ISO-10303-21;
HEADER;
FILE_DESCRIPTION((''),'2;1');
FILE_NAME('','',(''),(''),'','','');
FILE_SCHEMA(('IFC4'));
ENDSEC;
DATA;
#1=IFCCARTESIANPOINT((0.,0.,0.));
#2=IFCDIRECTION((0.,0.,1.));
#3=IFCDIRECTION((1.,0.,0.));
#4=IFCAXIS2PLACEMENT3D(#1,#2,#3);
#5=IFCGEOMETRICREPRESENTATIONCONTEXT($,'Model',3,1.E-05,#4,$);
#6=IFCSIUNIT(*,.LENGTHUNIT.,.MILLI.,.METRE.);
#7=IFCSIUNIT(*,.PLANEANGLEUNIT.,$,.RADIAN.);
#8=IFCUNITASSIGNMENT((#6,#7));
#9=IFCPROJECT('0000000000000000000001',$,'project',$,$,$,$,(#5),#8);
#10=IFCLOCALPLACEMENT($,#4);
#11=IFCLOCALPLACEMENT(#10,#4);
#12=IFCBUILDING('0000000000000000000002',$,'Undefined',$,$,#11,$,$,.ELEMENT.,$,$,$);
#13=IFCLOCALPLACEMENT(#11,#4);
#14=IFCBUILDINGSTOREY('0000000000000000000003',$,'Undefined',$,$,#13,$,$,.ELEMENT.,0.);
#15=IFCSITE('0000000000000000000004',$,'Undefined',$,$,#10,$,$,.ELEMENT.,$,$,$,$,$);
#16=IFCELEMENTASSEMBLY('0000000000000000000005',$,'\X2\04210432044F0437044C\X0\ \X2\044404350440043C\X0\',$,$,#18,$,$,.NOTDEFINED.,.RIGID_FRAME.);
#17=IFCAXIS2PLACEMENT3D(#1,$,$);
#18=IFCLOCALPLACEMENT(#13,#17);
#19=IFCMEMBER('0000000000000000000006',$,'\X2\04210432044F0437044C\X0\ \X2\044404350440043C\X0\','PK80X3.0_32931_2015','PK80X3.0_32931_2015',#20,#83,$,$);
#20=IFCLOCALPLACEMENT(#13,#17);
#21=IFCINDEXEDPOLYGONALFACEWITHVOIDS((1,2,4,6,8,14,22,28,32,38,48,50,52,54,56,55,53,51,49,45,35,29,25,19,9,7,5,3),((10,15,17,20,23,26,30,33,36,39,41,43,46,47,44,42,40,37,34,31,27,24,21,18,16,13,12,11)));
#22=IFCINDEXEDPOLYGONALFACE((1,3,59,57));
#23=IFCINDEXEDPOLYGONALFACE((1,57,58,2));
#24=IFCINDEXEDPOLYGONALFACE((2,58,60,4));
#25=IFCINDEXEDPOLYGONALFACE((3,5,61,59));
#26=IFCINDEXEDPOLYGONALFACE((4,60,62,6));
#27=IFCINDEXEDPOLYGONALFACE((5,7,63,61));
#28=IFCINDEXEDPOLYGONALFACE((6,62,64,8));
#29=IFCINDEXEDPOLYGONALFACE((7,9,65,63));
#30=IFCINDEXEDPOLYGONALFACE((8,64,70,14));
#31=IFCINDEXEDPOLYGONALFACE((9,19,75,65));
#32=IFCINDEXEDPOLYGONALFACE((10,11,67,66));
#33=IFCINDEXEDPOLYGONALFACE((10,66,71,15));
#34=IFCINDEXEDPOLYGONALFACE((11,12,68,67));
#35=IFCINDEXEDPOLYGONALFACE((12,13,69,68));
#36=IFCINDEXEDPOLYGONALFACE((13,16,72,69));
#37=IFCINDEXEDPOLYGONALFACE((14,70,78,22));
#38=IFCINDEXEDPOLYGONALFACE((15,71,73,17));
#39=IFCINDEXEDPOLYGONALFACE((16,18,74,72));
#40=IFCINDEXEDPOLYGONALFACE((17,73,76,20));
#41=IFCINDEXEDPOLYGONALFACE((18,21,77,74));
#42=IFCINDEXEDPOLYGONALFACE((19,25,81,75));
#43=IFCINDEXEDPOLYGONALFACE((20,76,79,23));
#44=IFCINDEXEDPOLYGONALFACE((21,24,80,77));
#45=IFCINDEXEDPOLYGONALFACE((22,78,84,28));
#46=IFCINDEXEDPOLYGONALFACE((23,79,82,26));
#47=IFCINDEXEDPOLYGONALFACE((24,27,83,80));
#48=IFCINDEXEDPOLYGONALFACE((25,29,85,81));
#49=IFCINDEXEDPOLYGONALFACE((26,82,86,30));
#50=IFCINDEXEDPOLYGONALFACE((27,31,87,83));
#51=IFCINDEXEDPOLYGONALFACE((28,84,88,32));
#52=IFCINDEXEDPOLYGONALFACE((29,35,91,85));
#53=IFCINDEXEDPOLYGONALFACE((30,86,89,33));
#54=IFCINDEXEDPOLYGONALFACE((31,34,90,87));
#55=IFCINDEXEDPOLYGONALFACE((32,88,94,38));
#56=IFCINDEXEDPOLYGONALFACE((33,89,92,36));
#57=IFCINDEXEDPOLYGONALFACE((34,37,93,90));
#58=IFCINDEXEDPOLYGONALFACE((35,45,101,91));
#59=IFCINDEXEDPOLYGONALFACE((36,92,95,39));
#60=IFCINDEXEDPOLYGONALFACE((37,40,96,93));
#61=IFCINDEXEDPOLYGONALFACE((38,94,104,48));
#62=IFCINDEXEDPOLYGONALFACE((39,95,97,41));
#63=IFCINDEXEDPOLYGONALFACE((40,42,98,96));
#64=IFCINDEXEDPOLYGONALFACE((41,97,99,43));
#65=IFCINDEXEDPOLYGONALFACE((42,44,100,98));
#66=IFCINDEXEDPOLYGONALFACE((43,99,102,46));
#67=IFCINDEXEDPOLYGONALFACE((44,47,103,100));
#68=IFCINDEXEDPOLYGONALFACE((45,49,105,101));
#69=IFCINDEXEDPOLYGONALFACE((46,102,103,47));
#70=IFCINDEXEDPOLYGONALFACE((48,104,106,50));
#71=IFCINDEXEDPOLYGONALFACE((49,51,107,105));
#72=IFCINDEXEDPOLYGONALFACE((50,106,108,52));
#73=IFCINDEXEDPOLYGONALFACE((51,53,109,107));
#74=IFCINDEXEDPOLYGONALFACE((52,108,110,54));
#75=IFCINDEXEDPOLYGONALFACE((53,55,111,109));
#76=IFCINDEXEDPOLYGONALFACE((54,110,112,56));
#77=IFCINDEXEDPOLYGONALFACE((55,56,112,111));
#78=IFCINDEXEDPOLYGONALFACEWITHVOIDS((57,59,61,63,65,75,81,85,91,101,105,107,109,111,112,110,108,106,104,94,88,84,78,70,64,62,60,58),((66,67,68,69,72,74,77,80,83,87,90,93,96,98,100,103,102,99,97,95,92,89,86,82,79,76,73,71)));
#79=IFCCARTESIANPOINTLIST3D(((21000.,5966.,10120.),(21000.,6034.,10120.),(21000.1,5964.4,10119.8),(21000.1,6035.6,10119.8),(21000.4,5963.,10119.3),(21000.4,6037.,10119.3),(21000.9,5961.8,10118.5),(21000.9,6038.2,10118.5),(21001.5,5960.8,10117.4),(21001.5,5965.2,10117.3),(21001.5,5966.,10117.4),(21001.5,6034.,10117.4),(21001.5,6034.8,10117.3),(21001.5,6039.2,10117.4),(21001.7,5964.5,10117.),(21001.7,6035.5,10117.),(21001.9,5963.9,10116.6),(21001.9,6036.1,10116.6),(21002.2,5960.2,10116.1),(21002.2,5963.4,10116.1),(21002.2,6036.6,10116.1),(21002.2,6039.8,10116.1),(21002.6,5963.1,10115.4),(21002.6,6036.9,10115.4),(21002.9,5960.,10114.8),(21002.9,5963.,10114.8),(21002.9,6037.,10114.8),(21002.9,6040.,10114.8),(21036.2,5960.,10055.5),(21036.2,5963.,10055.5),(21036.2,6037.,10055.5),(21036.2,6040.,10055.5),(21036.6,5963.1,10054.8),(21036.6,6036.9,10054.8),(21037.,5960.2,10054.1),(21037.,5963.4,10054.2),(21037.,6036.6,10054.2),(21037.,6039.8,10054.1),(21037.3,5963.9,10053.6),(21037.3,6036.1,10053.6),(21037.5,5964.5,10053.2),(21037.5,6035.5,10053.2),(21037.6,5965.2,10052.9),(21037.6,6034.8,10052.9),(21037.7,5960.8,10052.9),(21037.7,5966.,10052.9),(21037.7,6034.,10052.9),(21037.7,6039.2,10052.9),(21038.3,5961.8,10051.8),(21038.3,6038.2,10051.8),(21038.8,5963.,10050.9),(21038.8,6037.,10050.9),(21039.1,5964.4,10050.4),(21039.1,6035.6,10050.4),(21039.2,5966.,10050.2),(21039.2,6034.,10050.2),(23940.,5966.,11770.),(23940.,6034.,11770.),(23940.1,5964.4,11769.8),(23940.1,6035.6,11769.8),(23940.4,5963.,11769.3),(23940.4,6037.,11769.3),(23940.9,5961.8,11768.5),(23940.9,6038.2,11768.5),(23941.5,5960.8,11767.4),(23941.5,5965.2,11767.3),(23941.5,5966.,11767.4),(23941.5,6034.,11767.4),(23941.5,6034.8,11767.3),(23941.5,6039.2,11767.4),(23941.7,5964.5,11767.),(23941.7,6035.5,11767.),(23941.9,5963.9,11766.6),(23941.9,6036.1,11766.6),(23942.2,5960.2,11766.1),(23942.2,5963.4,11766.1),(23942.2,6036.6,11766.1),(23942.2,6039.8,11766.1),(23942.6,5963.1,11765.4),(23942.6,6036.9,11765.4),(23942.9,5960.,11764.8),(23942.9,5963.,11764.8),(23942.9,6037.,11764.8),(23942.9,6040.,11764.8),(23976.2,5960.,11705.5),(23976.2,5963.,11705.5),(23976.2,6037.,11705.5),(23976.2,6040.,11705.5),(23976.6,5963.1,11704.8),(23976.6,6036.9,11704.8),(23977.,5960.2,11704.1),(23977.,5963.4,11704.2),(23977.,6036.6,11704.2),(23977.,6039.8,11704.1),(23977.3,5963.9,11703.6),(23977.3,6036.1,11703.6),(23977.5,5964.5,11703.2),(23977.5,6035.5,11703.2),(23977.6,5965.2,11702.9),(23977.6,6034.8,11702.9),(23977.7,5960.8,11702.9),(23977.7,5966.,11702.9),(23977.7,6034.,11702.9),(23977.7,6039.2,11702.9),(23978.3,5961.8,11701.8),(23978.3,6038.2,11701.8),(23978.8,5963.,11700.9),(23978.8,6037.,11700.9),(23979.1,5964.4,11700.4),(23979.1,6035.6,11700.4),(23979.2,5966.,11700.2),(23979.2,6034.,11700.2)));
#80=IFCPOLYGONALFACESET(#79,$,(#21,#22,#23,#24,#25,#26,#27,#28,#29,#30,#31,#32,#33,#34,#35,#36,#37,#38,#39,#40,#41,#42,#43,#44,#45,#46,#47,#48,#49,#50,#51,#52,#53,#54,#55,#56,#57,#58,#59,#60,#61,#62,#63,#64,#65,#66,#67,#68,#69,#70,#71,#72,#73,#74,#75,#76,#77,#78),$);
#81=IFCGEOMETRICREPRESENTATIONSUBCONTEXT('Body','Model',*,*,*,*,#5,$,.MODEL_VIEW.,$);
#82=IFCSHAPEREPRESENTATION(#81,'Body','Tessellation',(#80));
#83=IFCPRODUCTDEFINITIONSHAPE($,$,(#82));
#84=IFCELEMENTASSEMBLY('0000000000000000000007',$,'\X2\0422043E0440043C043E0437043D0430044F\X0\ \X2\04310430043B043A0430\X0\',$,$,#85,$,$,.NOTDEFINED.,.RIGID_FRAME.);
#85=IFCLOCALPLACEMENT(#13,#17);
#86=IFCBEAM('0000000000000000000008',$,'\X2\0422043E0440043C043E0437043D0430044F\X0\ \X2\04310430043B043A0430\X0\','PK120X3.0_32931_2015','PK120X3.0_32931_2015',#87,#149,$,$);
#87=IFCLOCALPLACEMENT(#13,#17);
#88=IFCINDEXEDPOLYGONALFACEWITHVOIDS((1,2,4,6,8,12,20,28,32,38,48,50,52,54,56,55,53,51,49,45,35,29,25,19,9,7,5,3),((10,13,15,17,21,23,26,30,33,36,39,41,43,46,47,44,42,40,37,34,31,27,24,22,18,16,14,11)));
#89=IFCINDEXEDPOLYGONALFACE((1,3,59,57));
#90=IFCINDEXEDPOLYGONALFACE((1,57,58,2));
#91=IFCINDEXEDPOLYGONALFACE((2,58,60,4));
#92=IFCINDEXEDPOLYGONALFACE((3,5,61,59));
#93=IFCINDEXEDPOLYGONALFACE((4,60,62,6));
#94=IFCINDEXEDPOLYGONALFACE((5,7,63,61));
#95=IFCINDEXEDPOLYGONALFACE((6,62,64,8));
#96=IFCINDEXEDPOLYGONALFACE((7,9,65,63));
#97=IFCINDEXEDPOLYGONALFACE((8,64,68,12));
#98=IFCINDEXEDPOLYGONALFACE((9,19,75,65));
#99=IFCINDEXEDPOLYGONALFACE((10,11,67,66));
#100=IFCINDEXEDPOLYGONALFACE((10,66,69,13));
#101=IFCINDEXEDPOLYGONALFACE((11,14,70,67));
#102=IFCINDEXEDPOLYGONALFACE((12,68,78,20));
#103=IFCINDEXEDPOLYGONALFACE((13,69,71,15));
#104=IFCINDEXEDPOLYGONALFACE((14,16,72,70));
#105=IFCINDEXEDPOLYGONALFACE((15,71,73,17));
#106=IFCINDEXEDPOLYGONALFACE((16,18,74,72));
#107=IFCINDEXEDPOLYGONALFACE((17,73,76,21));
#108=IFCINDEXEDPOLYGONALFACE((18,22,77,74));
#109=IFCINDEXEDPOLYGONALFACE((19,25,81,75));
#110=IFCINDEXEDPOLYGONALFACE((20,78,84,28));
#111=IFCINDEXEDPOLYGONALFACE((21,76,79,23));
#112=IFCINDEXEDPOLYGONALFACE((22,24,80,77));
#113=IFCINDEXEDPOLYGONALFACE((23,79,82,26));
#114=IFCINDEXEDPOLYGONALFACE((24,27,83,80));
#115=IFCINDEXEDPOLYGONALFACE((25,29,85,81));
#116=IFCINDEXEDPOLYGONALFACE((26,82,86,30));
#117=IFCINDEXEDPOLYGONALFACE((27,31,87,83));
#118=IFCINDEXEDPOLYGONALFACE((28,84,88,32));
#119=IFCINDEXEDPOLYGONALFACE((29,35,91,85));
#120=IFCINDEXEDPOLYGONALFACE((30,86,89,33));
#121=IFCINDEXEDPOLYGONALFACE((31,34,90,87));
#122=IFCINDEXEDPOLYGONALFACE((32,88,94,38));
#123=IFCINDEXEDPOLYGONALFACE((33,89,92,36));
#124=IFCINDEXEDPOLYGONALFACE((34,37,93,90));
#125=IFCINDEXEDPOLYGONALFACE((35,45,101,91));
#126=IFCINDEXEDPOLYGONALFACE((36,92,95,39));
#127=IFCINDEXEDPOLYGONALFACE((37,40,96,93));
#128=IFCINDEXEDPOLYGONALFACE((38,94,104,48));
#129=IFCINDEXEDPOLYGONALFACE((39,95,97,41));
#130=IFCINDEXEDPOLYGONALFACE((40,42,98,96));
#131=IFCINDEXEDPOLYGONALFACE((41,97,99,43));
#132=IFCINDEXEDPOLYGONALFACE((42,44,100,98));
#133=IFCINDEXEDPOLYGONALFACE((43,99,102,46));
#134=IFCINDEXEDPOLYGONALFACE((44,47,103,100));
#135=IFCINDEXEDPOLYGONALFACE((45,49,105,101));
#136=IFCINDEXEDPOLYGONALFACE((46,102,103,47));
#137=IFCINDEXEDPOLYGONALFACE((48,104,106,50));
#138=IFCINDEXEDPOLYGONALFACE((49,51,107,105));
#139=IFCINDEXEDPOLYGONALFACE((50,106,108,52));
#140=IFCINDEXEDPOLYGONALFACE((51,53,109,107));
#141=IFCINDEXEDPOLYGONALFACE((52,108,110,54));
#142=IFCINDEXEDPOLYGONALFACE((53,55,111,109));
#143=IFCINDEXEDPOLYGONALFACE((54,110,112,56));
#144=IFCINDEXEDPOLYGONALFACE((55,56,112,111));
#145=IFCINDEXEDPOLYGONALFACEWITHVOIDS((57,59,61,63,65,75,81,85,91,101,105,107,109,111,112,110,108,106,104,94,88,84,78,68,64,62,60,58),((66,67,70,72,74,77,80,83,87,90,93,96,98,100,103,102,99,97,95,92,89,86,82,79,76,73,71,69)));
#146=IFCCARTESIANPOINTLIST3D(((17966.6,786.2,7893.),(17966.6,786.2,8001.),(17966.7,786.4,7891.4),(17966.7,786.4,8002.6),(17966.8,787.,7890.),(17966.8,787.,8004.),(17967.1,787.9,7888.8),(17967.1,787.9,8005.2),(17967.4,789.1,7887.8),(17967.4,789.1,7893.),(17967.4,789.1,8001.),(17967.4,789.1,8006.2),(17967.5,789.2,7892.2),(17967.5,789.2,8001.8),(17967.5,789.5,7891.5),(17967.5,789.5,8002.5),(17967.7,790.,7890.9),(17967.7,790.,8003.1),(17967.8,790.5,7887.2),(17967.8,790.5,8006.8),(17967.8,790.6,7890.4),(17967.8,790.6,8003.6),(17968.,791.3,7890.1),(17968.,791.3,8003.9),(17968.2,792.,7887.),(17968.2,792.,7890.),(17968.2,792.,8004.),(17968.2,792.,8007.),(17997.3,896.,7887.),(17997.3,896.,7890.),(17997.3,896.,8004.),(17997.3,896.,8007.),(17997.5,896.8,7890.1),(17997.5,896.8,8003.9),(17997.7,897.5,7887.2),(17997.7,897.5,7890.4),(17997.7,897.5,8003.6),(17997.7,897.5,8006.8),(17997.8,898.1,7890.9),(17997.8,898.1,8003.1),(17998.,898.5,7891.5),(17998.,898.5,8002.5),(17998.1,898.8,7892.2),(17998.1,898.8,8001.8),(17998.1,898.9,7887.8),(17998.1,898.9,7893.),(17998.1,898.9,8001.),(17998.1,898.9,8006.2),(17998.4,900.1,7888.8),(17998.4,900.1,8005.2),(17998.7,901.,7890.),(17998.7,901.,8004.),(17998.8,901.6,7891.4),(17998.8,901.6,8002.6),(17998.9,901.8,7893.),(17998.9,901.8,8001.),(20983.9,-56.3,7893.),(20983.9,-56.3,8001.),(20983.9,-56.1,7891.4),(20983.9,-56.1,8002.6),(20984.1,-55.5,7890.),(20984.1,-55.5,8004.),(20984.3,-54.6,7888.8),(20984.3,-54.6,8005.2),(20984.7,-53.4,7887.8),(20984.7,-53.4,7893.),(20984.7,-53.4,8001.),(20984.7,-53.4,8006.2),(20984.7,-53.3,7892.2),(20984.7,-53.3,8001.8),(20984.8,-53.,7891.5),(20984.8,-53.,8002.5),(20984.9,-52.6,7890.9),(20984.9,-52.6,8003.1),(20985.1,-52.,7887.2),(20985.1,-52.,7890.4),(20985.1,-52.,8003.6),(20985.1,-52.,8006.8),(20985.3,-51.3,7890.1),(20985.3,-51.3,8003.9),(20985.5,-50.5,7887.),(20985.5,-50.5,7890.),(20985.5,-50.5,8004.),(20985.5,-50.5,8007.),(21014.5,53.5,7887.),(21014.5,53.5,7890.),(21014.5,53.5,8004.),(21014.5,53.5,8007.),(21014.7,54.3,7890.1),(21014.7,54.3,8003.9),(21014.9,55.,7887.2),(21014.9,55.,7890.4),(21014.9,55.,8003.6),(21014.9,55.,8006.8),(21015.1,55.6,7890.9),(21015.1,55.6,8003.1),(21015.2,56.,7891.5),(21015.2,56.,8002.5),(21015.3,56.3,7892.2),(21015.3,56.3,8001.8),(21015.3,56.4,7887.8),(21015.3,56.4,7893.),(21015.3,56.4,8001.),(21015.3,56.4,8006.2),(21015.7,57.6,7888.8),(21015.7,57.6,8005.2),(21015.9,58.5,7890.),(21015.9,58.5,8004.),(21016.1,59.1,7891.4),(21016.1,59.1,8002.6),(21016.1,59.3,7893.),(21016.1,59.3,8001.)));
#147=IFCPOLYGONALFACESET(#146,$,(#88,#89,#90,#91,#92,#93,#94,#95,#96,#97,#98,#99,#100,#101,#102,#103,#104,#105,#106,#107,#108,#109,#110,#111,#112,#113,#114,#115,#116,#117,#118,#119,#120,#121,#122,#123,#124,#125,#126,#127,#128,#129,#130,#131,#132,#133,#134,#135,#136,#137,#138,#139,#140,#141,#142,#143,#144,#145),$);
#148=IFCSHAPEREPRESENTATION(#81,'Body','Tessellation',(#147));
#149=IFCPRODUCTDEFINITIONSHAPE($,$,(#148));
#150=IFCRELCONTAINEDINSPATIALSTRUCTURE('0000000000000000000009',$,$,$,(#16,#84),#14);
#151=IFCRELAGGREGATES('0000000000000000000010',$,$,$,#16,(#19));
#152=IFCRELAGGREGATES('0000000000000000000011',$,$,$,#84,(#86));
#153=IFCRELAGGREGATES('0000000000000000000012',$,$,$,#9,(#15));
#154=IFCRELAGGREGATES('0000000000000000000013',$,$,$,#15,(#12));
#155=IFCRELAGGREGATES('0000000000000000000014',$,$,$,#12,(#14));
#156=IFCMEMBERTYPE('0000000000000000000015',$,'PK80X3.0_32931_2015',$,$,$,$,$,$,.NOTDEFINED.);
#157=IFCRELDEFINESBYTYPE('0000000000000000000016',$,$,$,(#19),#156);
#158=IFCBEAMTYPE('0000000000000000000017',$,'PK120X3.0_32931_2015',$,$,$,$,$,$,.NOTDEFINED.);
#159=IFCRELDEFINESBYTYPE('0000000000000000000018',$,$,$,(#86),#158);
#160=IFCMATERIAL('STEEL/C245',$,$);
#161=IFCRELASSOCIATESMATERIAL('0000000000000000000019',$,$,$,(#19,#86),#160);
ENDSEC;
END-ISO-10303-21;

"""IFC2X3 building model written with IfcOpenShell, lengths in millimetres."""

from ifc_helpers import new_model, si_unit, frame, origin_with_axes, origin_2d_with_axis, place, context, subcontext, project, spatial, hollow_rectangle, extrude, material, type_object, element, aggregate, save


model = new_model("IFC2X3")

# Units and contexts
model_context = context("Model", 3, precision=1e-05, world=origin_with_axes())
body_context = subcontext(model_context, "Body", "Model", "MODEL_VIEW")
ifc_project = project(units=[si_unit("LENGTHUNIT", "METRE", prefix="MILLI"), si_unit("PLANEANGLEUNIT", "RADIAN")], contexts=[model_context])

# Site, building, storey
site_placement = place(None, origin_with_axes())
site = spatial("IfcSite", under=ifc_project, at=site_placement, Name="Undefined", CompositionType="ELEMENT")
building_placement = place(site_placement, origin_with_axes())
building = spatial("IfcBuilding", under=site, at=building_placement, Name="Undefined", CompositionType="ELEMENT")
storey_placement = place(building_placement, origin_with_axes())
storey = spatial("IfcBuildingStorey", under=building, at=storey_placement, Name="Undefined", CompositionType="ELEMENT", Elevation=0.0)

# Shared definitions
ifc_material_1 = material(Name="STEEL/C245")

# Element assembly, member
assembly_1_placement = place(storey_placement, origin_with_axes())
assembly_1 = element("IfcElementAssembly", 1, at=assembly_1_placement, inside=storey, Name="Связь ферм", AssemblyPlace="NOTDEFINED", PredefinedType="RIGID_FRAME")
member_type_1 = type_object("IfcMemberType", Name="PK80X3.0_32931_2015", PredefinedType="NOTDEFINED")
member_1_placement = place(assembly_1_placement, frame((21019.6, 6000.0, 10085.1), z_axis=(-0.489416, 0.0, 0.87205), x_axis=(0.87205, 0.0, 0.489416)))
member_1 = element("IfcMember", 2, at=member_1_placement, type_object=member_type_1, material=ifc_material_1, Name="Связь ферм", Description="PK80X3.0_32931_2015", ObjectType="PK80X3.0_32931_2015", context=body_context, shape_type="SweptSolid", body=[
    extrude(hollow_rectangle(XDim=80.0, YDim=80.0, WallThickness=3.0, InnerFilletRadius=3.0, OuterFilletRadius=6.0, at=origin_2d_with_axis()), frame((3371.4, 0.0, 0.0), z_axis=(-1.0, 0.0, 0.0), x_axis=(0.0, -1.0, 0.0)), (0.0, 0.0, 1.0), 3371.4),
])
aggregate(assembly_1, [member_1])

# Element assembly, beam
assembly_2_placement = place(storey_placement, origin_with_axes())
assembly_2 = element("IfcElementAssembly", 3, at=assembly_2_placement, inside=storey, Name="Тормозная балка", AssemblyPlace="NOTDEFINED", PredefinedType="RIGID_FRAME")
beam_type_1 = type_object("IfcBeamType", Name="PK120X3.0_32931_2015", PredefinedType="NOTDEFINED")
beam_1_placement = place(assembly_2_placement, frame((17982.8, 844.0, 7947.0), z_axis=(0.0, 0.0, -1.0), x_axis=(0.963154, -0.26895, 0.0)))
beam_1 = element("IfcBeam", 4, at=beam_1_placement, type_object=beam_type_1, material=ifc_material_1, Name="Тормозная балка", Description="PK120X3.0_32931_2015", ObjectType="PK120X3.0_32931_2015", context=body_context, shape_type="SweptSolid", body=[
    extrude(hollow_rectangle(XDim=120.0, YDim=120.0, WallThickness=3.0, InnerFilletRadius=3.0, OuterFilletRadius=6.0, at=origin_2d_with_axis()), frame((3132.7, 0.0, 0.0), z_axis=(-1.0, 0.0, 0.0), x_axis=(0.0, -1.0, 0.0)), (0.0, 0.0, 1.0), 3132.7),
])
aggregate(assembly_2, [beam_1])

save(model, "model.ifc")
